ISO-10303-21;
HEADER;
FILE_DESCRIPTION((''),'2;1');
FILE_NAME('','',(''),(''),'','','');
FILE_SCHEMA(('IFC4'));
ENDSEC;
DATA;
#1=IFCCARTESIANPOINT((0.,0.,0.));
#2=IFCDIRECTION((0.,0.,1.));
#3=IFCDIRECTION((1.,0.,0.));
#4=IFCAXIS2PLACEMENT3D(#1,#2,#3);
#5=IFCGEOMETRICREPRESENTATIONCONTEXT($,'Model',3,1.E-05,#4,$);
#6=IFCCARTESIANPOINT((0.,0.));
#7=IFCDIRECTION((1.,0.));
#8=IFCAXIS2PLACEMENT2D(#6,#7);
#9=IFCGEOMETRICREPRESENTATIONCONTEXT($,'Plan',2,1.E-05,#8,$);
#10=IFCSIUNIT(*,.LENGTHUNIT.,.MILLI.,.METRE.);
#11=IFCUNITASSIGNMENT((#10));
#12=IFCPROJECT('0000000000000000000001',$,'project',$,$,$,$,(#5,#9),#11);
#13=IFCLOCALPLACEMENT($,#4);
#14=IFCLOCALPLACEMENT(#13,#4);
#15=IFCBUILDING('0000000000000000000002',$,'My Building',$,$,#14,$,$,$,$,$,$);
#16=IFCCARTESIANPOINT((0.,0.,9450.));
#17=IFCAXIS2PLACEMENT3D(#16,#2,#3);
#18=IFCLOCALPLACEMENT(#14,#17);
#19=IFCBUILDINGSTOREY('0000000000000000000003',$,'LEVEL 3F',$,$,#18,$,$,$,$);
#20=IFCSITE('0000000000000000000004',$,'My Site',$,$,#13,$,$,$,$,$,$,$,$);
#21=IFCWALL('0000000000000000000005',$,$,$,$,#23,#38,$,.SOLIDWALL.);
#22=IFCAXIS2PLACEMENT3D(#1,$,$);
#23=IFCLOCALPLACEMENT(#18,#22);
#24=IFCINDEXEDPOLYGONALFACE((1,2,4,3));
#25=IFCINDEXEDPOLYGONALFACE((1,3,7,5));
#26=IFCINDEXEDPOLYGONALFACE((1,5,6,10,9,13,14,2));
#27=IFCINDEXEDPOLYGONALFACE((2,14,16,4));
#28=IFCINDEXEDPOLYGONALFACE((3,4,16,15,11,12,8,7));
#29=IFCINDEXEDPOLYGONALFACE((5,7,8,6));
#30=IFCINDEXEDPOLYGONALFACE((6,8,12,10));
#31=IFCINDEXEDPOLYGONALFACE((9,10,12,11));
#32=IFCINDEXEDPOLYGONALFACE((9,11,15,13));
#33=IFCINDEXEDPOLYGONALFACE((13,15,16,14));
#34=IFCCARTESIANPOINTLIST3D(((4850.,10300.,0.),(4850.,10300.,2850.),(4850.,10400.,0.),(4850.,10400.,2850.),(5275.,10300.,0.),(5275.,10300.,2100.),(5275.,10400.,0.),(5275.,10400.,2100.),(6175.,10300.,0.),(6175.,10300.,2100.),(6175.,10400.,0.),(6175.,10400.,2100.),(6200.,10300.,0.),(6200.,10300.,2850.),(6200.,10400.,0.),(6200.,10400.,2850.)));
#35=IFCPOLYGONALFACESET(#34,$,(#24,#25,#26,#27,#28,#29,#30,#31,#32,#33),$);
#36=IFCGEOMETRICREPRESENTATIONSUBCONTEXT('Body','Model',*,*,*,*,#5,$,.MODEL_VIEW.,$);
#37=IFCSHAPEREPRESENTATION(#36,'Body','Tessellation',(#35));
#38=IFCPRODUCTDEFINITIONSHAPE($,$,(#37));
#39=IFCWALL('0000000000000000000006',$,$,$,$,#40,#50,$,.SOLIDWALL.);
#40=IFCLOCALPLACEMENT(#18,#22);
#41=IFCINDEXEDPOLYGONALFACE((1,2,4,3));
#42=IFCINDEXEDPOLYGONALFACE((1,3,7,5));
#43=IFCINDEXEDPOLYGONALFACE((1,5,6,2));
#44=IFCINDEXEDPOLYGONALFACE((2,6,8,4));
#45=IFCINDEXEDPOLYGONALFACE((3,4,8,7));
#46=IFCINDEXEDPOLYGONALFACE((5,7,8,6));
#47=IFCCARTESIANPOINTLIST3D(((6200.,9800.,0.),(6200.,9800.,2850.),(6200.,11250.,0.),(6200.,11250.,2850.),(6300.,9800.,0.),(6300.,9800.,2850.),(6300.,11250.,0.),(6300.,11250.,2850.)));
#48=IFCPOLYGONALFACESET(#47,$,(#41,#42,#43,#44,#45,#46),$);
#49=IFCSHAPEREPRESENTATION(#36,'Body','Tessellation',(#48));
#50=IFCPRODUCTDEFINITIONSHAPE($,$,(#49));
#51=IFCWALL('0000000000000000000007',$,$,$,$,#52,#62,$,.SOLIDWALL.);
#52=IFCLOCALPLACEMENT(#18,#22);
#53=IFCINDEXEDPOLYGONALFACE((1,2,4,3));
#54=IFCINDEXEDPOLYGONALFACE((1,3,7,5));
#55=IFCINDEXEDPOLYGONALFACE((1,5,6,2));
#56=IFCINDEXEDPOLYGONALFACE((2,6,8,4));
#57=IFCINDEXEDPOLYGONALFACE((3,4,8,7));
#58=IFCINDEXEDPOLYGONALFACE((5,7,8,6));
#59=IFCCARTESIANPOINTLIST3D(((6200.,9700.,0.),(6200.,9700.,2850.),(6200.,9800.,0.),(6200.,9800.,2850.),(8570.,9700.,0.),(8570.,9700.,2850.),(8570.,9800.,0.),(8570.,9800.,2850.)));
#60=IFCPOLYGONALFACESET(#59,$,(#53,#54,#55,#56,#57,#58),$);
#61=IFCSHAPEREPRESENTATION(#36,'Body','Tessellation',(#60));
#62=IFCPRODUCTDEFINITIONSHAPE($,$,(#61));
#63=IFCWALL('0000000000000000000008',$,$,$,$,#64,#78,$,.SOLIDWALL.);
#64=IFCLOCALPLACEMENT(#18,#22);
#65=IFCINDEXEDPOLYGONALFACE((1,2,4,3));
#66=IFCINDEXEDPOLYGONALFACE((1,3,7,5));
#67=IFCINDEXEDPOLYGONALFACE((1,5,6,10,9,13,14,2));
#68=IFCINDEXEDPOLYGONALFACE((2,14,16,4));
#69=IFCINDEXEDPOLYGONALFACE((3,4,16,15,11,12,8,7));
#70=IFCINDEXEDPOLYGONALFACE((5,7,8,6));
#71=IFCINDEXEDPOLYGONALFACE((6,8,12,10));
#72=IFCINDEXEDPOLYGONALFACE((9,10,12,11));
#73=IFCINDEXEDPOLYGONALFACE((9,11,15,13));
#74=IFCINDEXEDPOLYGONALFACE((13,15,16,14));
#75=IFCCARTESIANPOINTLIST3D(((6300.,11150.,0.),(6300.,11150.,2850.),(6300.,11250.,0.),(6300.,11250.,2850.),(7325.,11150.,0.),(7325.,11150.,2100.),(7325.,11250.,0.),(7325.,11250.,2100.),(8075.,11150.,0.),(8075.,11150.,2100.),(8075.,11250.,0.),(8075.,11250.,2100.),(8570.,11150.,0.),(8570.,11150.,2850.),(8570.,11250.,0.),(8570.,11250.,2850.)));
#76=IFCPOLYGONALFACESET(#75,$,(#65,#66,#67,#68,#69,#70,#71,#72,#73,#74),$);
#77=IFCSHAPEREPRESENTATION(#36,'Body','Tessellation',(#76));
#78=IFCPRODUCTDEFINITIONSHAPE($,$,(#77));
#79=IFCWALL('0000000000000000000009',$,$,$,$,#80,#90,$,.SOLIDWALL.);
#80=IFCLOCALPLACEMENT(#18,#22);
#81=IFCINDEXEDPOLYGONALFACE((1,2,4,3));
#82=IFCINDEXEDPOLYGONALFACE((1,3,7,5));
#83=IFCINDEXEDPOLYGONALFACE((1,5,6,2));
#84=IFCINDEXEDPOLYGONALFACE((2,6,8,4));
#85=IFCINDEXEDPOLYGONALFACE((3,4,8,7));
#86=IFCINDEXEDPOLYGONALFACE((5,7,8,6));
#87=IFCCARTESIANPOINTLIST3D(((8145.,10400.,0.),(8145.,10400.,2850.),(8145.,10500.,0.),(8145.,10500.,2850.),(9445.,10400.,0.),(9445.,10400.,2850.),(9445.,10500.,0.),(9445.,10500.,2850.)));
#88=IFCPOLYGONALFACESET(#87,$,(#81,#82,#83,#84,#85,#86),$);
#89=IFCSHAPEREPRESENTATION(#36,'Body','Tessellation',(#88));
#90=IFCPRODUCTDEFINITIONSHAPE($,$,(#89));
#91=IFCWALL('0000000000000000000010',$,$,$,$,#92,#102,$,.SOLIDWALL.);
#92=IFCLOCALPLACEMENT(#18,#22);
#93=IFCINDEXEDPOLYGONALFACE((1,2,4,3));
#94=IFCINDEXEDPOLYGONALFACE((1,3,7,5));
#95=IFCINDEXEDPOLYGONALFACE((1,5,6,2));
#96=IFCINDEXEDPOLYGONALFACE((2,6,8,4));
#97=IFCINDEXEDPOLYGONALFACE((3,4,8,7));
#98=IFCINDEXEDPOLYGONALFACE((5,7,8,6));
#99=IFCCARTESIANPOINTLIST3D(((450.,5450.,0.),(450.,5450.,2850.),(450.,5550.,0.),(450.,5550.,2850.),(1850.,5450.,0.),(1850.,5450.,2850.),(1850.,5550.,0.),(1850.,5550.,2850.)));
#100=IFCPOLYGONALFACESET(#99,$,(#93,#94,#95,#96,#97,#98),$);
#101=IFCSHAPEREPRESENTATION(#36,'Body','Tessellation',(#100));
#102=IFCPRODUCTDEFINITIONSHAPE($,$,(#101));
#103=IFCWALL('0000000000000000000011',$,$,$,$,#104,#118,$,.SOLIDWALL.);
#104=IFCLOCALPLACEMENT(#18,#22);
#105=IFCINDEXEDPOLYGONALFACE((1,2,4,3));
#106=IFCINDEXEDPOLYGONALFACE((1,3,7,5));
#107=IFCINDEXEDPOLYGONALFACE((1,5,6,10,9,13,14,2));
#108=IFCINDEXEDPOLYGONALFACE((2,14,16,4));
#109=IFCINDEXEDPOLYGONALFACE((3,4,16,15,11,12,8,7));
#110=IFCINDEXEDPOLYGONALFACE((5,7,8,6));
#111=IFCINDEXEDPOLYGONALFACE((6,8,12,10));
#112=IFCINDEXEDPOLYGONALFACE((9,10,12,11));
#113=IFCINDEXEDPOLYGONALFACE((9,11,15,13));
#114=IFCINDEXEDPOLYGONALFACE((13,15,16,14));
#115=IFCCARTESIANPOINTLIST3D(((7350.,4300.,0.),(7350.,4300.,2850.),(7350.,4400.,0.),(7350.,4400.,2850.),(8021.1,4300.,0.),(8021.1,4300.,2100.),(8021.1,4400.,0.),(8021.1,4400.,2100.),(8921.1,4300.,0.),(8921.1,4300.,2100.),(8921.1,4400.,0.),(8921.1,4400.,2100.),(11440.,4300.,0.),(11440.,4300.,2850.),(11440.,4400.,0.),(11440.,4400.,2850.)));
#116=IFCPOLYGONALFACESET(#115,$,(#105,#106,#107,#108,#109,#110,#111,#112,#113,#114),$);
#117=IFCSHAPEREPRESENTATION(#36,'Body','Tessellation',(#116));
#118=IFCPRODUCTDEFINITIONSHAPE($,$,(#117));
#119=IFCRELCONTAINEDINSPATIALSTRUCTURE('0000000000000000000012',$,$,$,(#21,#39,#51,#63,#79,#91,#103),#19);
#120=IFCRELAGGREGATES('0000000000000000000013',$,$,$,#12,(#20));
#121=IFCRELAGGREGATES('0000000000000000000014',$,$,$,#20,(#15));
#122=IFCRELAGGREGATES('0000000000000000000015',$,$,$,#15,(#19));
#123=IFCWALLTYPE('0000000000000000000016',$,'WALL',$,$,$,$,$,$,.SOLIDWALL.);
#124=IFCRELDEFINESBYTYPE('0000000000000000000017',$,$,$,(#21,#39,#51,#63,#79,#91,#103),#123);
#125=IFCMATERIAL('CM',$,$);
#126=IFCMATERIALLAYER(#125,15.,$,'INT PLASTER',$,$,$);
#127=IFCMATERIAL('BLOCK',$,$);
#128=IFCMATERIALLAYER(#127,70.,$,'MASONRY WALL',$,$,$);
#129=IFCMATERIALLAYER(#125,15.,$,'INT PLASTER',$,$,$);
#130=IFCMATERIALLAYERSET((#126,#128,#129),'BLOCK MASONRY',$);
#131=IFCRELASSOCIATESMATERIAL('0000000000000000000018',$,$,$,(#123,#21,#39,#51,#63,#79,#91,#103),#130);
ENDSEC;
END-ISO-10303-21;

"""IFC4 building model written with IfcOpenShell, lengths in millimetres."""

from ifc_helpers import new_model, si_unit, frame, origin_with_axes, origin_2d_with_axis, place, context, subcontext, project, spatial, indexed_curve, outline, extrude, material, layer, layer_set, layer_usage, type_object, element, save


model = new_model("IFC4")

# Units and contexts
model_context = context("Model", 3, precision=1e-05, world=origin_with_axes())
plan_context = context("Plan", 2, precision=1e-05, world=origin_2d_with_axis())
body_context = subcontext(model_context, "Body", "Model", "MODEL_VIEW")
ifc_project = project(units=[si_unit("LENGTHUNIT", "METRE", prefix="MILLI")], contexts=[model_context, plan_context])

# Site, building, storey
site_placement = place(None, origin_with_axes())
site = spatial("IfcSite", under=ifc_project, at=site_placement, Name="My Site")
building_placement = place(site_placement, origin_with_axes())
building = spatial("IfcBuilding", under=site, at=building_placement, Name="My Building")
storey_placement = place(building_placement, frame((0.0, 0.0, 9450.0), z_axis=(0.0, 0.0, 1.0), x_axis=(1.0, 0.0, 0.0)))
storey = spatial("IfcBuildingStorey", under=building, at=storey_placement, Name="LEVEL 3F")

# Shared definitions
ifc_material_1 = material(Name="CM")
ifc_layer_1 = layer(ifc_material_1, 15.0, Name="INT PLASTER")
ifc_material_2 = material(Name="BLOCK")
ifc_layer_2 = layer(ifc_material_2, 70.0, Name="MASONRY WALL")
ifc_layer_3 = layer(ifc_material_1, 15.0, Name="INT PLASTER")
ifc_layer_set = layer_set([ifc_layer_1, ifc_layer_2, ifc_layer_3], Name="BLOCK MASONRY")
wall_type = type_object("IfcWallType", Name="WALL", PredefinedType="SOLIDWALL", material=ifc_layer_set)

# Wall, opening
ifc_layer_usage_1 = layer_usage(ifc_layer_set, "AXIS2", "POSITIVE", 0.0)
wall_1_placement = place(storey_placement, frame((4850.0, 10400.0, 0.0), z_axis=(0.0, 0.0, 1.0), x_axis=(0.0, -1.0, 0.0)))
wall_1 = element("IfcWall", 1, at=wall_1_placement, inside=storey, type_object=wall_type, material=ifc_layer_usage_1, PredefinedType="SOLIDWALL", context=body_context, shape_type="SweptSolid", body=[
    extrude(outline(indexed_curve([(0.0, 0.0), (0.0, 1350.0), (100.0, 1350.0), (100.0, 0.0), (0.0, 0.0)], self_intersect=False)), origin_with_axes(), (0.0, 0.0, 1.0), 2850.0),
])
opening_1_placement = place(wall_1_placement, frame((100.0, 425.0, 0.0), z_axis=(0.0, 0.0, 1.0), x_axis=(0.0, 1.0, 0.0)))
element("IfcOpeningElement", 2, at=opening_1_placement, cuts=wall_1, PredefinedType="OPENING", context=body_context, shape_type="SweptSolid", body=[
    extrude(outline(indexed_curve([(0.0, 0.0), (0.0, 400.0), (900.0, 400.0), (900.0, 0.0), (0.0, 0.0)], self_intersect=False)), frame((0.0, -100.0, 0.0), z_axis=(0.0, 0.0, 1.0), x_axis=(1.0, 0.0, 0.0)), (0.0, 0.0, 1.0), 2100.0),
])

# Walls
ifc_layer_usage_2 = layer_usage(ifc_layer_set, "AXIS2", "POSITIVE", 0.0)
wall_2_placement = place(storey_placement, frame((6300.0, 9800.0, 0.0), z_axis=(0.0, 0.0, 1.0), x_axis=(0.0, 1.0, 0.0)))
element("IfcWall", 3, at=wall_2_placement, inside=storey, type_object=wall_type, material=ifc_layer_usage_2, PredefinedType="SOLIDWALL", context=body_context, shape_type="SweptSolid", body=[
    extrude(outline(indexed_curve([(0.0, 0.0), (0.0, 100.0), (1450.0, 100.0), (1450.0, 0.0), (0.0, 0.0)], self_intersect=False)), origin_with_axes(), (0.0, 0.0, 1.0), 2850.0),
])
ifc_layer_usage_3 = layer_usage(ifc_layer_set, "AXIS2", "POSITIVE", 0.0)
wall_3_placement = place(storey_placement, frame((6200.0, 9800.0, 0.0), z_axis=(0.0, 0.0, 1.0), x_axis=(0.0, -1.0, 0.0)))
element("IfcWall", 4, at=wall_3_placement, inside=storey, type_object=wall_type, material=ifc_layer_usage_3, PredefinedType="SOLIDWALL", context=body_context, shape_type="SweptSolid", body=[
    extrude(outline(indexed_curve([(0.0, 0.0), (0.0, 2370.0), (100.0, 2370.0), (100.0, 0.0), (0.0, 0.0)], self_intersect=False)), origin_with_axes(), (0.0, 0.0, 1.0), 2850.0),
])

# Wall, opening
ifc_layer_usage_4 = layer_usage(ifc_layer_set, "AXIS2", "POSITIVE", 0.0)
wall_4_placement = place(storey_placement, frame((6300.0, 11250.0, 0.0), z_axis=(0.0, 0.0, 1.0), x_axis=(0.0, -1.0, 0.0)))
wall_4 = element("IfcWall", 5, at=wall_4_placement, inside=storey, type_object=wall_type, material=ifc_layer_usage_4, PredefinedType="SOLIDWALL", context=body_context, shape_type="SweptSolid", body=[
    extrude(outline(indexed_curve([(0.0, 0.0), (0.0, 2270.0), (100.0, 2270.0), (100.0, 0.0), (0.0, 0.0)], self_intersect=False)), origin_with_axes(), (0.0, 0.0, 1.0), 2850.0),
])
opening_2_placement = place(wall_4_placement, frame((0.0, 1775.0, 0.0), z_axis=(0.0, 0.0, 1.0), x_axis=(0.0, -1.0, 0.0)))
element("IfcOpeningElement", 6, at=opening_2_placement, cuts=wall_4, PredefinedType="OPENING", context=body_context, shape_type="SweptSolid", body=[
    extrude(outline(indexed_curve([(0.0, 0.0), (0.0, 400.0), (750.0, 400.0), (750.0, 0.0), (0.0, 0.0)], self_intersect=False)), frame((0.0, -100.0, 0.0), z_axis=(0.0, 0.0, 1.0), x_axis=(1.0, 0.0, 0.0)), (0.0, 0.0, 1.0), 2100.0),
])

# Walls
ifc_layer_usage_5 = layer_usage(ifc_layer_set, "AXIS2", "POSITIVE", 0.0)
wall_5_placement = place(storey_placement, frame((8145.0, 10500.0, 0.0), z_axis=(0.0, 0.0, 1.0), x_axis=(0.0, -1.0, 0.0)))
element("IfcWall", 7, at=wall_5_placement, inside=storey, type_object=wall_type, material=ifc_layer_usage_5, PredefinedType="SOLIDWALL", context=body_context, shape_type="SweptSolid", body=[
    extrude(outline(indexed_curve([(0.0, 0.0), (0.0, 1300.0), (100.0, 1300.0), (100.0, 0.0), (0.0, 0.0)], self_intersect=False)), origin_with_axes(), (0.0, 0.0, 1.0), 2850.0),
])
ifc_layer_usage_6 = layer_usage(ifc_layer_set, "AXIS2", "POSITIVE", 0.0)
wall_6_placement = place(storey_placement, frame((450.0, 5550.0, 0.0), z_axis=(0.0, 0.0, 1.0), x_axis=(0.0, -1.0, 0.0)))
element("IfcWall", 8, at=wall_6_placement, inside=storey, type_object=wall_type, material=ifc_layer_usage_6, PredefinedType="SOLIDWALL", context=body_context, shape_type="SweptSolid", body=[
    extrude(outline(indexed_curve([(0.0, 0.0), (0.0, 1400.0), (100.0, 1400.0), (100.0, 0.0), (0.0, 0.0)], self_intersect=False)), origin_with_axes(), (0.0, 0.0, 1.0), 2850.0),
])

# Wall, opening
ifc_layer_usage_7 = layer_usage(ifc_layer_set, "AXIS2", "POSITIVE", 0.0)
wall_7_placement = place(storey_placement, frame((7350.0, 4400.0, 0.0), z_axis=(0.0, 0.0, 1.0), x_axis=(0.0, -1.0, 0.0)))
wall_7 = element("IfcWall", 9, at=wall_7_placement, inside=storey, type_object=wall_type, material=ifc_layer_usage_7, PredefinedType="SOLIDWALL", context=body_context, shape_type="SweptSolid", body=[
    extrude(outline(indexed_curve([(0.0, 0.0), (0.0, 4090.0), (100.0, 4090.0), (100.0, 0.0), (0.0, 0.0)], self_intersect=False)), origin_with_axes(), (0.0, 0.0, 1.0), 2850.0),
])
opening_3_placement = place(wall_7_placement, frame((-25.0, 1571.1, 0.0), z_axis=(0.0, 0.0, 1.0), x_axis=(0.0, -1.0, 0.0)))
element("IfcOpeningElement", 10, at=opening_3_placement, cuts=wall_7, PredefinedType="OPENING", context=body_context, shape_type="SweptSolid", body=[
    extrude(outline(indexed_curve([(0.0, 0.0), (0.0, 400.0), (900.0, 400.0), (900.0, 0.0), (0.0, 0.0)], self_intersect=False)), frame((0.0, -100.0, 0.0), z_axis=(0.0, 0.0, 1.0), x_axis=(1.0, 0.0, 0.0)), (0.0, 0.0, 1.0), 2100.0),
])

save(model, "model.ifc")
